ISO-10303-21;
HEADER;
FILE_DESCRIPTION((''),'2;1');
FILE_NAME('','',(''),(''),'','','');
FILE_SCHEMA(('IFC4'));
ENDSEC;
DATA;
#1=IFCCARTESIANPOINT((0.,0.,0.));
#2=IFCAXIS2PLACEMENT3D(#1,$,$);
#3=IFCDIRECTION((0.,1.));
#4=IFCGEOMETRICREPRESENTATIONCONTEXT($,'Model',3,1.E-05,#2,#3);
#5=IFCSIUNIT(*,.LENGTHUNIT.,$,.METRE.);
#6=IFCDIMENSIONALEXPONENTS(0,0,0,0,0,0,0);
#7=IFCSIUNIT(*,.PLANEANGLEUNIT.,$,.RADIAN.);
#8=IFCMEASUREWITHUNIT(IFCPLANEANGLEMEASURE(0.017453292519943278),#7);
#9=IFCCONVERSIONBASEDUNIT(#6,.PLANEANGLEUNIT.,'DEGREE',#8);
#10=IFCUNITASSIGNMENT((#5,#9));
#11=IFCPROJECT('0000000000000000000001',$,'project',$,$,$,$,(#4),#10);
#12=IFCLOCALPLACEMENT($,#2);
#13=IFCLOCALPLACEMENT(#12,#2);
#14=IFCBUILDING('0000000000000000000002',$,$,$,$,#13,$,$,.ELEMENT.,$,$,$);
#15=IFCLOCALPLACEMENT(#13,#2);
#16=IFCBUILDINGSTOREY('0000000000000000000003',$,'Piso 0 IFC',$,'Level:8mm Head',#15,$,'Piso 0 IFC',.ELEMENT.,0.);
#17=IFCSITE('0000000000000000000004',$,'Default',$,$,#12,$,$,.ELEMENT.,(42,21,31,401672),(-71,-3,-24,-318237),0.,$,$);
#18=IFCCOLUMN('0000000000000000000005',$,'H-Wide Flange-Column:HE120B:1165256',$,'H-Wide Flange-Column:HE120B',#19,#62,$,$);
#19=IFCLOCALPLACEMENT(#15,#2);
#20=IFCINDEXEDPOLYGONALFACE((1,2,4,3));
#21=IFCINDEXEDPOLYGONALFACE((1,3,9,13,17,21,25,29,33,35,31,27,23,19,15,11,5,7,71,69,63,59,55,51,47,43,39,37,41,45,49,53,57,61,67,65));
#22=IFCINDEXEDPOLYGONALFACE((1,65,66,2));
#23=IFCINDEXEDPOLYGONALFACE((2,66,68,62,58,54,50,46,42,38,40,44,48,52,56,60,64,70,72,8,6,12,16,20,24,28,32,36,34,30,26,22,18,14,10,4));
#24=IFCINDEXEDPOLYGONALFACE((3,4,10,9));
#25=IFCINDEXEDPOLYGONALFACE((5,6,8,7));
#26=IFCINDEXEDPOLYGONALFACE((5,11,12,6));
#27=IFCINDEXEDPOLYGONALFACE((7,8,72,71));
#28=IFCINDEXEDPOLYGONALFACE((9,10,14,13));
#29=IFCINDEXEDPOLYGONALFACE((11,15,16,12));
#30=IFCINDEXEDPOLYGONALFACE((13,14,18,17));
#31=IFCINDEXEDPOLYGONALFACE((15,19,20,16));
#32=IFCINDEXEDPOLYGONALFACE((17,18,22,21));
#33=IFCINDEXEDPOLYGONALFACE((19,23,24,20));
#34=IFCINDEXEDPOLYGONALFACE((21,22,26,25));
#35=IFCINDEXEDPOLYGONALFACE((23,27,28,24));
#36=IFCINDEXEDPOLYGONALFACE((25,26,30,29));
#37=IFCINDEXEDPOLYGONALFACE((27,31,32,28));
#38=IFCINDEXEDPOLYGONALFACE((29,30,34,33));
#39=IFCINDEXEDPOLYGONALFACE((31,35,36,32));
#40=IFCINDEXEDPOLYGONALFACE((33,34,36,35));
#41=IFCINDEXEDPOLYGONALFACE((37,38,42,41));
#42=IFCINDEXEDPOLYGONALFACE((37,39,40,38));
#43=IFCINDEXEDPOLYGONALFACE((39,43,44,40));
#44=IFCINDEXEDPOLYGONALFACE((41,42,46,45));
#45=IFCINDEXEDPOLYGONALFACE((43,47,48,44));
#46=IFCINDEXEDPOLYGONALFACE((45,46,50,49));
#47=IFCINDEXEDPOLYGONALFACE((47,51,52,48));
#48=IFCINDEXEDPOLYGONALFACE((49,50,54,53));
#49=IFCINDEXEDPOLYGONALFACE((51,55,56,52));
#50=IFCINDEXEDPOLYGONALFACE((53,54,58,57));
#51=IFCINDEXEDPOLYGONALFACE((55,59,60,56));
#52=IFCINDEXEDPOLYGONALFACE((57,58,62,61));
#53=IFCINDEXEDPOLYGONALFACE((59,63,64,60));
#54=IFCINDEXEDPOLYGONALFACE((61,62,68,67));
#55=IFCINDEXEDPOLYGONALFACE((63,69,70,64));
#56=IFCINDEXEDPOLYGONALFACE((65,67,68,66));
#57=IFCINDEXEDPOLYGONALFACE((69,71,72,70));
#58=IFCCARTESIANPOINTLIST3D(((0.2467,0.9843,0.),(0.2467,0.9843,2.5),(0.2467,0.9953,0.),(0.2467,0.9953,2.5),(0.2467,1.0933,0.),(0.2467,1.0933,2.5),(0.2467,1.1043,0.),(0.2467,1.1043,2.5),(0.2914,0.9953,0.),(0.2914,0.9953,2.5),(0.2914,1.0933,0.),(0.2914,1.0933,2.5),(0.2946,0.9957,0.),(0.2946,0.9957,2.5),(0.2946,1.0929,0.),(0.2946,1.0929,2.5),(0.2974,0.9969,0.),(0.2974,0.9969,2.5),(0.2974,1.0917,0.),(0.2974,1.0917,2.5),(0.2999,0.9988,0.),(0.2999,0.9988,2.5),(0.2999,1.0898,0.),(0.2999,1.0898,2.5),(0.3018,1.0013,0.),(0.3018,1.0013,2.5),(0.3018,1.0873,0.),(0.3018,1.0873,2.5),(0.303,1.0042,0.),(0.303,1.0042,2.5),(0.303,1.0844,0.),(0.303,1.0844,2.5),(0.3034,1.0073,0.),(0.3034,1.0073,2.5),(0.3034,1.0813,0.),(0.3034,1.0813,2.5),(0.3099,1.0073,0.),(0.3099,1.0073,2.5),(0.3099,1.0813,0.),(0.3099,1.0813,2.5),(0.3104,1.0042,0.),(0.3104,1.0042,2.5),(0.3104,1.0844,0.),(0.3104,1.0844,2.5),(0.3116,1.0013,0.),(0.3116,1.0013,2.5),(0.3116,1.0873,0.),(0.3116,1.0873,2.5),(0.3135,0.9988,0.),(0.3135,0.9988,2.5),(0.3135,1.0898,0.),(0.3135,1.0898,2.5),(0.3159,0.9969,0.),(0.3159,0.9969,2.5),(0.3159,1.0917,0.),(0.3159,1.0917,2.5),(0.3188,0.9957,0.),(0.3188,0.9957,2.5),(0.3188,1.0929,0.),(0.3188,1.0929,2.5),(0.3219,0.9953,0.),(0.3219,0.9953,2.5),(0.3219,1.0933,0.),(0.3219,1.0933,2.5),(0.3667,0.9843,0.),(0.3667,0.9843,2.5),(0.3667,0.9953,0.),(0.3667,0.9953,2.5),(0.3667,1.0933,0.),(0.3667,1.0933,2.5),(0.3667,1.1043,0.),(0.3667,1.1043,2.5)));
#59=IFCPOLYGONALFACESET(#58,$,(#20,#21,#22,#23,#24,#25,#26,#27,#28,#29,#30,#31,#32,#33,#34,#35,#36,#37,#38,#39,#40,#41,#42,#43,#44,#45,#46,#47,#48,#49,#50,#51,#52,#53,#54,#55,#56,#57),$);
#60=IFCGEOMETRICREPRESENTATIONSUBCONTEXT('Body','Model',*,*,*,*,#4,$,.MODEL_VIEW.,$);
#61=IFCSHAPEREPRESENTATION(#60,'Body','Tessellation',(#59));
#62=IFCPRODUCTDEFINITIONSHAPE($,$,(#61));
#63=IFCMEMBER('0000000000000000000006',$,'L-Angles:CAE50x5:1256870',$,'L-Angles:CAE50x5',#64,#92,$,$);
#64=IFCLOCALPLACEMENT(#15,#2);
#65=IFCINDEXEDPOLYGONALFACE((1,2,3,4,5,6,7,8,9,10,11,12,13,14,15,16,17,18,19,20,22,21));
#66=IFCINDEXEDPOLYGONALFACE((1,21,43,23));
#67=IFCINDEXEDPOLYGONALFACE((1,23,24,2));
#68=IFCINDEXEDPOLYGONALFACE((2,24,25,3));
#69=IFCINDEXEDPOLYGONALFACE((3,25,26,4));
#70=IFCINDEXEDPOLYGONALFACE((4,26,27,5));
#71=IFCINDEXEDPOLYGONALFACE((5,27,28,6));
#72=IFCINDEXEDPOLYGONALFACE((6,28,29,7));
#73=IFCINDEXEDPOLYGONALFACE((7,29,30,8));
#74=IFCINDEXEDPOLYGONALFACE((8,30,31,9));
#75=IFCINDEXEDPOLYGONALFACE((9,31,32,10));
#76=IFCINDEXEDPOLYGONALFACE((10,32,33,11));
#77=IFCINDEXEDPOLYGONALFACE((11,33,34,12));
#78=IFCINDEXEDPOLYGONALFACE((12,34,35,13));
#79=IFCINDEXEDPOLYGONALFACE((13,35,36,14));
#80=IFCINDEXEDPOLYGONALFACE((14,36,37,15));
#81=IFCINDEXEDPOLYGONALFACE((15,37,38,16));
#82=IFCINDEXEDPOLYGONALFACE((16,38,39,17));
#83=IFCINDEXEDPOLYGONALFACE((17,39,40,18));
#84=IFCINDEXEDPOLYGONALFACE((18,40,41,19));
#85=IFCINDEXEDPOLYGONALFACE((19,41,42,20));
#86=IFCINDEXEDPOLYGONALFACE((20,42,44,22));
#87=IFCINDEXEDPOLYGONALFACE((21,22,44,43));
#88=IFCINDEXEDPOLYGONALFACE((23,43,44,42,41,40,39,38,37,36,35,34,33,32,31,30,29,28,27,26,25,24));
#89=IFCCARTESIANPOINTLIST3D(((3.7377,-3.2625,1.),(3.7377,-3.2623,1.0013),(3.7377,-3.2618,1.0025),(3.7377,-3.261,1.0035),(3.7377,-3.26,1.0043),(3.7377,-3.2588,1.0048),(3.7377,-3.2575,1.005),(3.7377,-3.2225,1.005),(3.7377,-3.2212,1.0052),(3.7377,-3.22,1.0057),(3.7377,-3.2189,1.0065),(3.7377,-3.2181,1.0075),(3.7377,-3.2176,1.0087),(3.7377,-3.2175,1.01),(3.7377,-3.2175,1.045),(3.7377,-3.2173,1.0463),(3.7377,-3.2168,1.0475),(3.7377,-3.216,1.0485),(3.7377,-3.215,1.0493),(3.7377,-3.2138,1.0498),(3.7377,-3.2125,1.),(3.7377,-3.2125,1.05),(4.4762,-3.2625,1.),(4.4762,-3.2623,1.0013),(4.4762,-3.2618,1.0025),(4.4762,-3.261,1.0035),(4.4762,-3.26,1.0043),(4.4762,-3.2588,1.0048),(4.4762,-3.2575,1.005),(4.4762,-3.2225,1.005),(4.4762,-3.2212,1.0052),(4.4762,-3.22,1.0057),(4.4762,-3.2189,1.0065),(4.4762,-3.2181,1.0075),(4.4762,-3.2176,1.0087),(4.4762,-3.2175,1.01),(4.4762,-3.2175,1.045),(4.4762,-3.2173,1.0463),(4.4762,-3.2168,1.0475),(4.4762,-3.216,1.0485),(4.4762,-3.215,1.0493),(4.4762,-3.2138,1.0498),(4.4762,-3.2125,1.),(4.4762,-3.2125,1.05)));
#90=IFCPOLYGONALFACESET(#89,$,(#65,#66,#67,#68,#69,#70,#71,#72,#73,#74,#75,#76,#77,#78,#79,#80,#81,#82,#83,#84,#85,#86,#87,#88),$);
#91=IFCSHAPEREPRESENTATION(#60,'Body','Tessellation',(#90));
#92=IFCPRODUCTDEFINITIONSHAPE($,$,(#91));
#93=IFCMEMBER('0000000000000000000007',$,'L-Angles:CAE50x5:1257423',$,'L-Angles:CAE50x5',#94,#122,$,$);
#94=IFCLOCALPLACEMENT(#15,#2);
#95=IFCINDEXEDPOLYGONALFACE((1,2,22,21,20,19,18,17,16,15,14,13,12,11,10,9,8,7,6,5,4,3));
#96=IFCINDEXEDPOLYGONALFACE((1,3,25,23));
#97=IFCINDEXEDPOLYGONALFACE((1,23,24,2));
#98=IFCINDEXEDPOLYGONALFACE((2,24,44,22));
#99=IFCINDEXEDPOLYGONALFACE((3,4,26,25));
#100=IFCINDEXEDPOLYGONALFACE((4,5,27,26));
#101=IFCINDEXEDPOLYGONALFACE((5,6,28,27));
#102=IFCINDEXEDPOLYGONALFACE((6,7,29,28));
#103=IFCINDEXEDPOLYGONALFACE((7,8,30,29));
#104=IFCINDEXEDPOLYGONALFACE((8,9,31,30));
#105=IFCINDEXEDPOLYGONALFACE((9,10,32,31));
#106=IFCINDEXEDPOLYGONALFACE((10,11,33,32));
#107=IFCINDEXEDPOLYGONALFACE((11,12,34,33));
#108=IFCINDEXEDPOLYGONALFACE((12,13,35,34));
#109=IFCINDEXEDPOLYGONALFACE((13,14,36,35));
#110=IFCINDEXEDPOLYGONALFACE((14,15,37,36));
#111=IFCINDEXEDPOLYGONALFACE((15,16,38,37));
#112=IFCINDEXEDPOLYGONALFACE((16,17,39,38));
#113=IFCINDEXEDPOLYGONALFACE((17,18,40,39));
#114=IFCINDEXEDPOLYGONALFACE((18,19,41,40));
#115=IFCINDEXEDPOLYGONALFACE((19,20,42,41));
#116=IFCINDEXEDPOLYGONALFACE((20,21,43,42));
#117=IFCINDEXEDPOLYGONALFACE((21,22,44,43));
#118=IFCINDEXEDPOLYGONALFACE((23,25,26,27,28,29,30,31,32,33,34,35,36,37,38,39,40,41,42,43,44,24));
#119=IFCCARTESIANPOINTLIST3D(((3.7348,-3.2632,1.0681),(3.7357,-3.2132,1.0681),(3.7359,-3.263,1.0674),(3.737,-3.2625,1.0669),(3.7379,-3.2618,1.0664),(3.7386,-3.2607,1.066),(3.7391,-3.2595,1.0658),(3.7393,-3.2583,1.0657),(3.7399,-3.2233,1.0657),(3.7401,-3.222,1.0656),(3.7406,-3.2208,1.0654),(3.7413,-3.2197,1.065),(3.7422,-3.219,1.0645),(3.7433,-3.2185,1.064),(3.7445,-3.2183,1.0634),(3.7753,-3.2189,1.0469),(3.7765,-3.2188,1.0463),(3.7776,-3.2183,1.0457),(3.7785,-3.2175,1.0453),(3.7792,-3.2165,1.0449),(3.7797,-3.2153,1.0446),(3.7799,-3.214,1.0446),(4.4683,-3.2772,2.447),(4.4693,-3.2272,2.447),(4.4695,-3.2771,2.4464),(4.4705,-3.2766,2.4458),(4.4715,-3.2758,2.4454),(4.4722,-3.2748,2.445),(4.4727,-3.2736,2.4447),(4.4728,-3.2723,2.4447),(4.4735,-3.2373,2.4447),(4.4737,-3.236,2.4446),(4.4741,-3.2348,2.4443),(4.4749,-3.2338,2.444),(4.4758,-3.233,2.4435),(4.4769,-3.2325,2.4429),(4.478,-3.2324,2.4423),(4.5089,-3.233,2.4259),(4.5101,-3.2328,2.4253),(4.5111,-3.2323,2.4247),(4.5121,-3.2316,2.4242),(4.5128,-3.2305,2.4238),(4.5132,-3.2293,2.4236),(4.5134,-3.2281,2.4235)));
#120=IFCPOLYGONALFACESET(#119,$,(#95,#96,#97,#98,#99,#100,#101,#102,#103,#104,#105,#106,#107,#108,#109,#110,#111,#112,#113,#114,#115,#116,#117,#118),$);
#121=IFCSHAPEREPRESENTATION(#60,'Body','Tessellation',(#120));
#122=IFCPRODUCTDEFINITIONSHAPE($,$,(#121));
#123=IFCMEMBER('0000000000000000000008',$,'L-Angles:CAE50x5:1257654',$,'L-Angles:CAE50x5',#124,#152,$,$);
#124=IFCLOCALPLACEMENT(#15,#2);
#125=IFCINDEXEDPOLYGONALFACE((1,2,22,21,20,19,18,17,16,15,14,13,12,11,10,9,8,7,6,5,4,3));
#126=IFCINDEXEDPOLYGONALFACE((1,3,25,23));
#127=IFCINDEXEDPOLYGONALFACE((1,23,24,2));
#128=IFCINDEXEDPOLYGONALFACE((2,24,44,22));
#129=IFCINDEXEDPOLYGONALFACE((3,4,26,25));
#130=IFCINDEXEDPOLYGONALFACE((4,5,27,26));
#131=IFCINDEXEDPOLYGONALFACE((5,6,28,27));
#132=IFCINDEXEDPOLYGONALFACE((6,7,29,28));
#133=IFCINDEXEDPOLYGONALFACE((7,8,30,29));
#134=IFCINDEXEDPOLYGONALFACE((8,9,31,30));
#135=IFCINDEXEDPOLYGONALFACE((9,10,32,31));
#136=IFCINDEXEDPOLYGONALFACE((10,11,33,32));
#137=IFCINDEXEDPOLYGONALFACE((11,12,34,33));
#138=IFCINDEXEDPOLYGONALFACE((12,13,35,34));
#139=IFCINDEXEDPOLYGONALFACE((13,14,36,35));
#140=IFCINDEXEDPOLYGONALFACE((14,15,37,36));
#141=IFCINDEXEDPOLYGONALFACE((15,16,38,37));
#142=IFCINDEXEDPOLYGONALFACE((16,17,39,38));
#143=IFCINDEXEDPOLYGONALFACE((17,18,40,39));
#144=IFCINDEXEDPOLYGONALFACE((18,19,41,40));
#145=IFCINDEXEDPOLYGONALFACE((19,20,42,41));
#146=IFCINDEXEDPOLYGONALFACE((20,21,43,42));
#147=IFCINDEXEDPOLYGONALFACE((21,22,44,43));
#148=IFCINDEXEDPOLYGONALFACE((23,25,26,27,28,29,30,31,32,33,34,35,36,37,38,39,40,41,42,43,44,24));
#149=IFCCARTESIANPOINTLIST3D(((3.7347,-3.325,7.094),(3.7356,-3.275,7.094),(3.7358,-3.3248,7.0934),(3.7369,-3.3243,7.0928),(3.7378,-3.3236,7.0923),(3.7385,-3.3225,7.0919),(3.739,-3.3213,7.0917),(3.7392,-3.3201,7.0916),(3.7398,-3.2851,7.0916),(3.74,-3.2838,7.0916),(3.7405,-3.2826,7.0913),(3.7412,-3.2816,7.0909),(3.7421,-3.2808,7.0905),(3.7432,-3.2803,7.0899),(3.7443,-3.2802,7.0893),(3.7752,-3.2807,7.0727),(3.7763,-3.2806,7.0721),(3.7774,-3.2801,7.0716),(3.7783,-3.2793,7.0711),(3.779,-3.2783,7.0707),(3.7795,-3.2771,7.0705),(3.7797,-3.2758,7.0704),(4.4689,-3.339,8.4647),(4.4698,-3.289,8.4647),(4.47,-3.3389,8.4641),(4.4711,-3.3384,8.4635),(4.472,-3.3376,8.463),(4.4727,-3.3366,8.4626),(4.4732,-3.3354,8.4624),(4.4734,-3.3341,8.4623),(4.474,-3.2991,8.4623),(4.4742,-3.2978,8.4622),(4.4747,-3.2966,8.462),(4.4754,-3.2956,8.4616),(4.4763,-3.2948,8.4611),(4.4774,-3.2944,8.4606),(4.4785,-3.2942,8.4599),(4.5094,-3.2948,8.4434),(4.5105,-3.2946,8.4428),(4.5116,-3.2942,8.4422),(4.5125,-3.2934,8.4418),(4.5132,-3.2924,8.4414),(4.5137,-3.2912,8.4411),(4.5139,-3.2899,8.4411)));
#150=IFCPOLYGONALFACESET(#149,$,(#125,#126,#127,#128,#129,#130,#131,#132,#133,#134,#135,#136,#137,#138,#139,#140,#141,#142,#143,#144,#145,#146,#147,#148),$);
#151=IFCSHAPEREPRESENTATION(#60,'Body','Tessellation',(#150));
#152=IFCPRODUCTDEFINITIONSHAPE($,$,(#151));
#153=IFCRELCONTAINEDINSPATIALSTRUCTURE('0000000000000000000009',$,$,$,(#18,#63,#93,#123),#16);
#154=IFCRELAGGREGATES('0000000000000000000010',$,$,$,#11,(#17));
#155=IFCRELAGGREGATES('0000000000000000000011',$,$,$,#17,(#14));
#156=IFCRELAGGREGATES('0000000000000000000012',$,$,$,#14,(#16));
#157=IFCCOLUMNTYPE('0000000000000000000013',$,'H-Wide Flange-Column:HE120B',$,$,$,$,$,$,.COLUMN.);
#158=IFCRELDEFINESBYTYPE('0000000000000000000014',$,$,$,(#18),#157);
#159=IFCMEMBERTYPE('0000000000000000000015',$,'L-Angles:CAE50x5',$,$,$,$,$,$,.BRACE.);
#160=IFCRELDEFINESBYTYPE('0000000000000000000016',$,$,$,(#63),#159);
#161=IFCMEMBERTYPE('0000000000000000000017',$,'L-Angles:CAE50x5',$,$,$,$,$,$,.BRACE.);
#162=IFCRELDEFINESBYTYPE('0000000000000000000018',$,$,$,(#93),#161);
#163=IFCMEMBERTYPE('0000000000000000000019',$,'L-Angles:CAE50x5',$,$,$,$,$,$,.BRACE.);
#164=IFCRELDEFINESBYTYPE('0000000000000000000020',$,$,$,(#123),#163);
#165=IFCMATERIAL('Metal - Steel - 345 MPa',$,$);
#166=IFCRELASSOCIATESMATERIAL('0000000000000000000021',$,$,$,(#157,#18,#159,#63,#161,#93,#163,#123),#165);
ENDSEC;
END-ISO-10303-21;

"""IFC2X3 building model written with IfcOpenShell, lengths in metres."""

from ifc_helpers import new_model, entity, si_unit, converted_unit, direction, frame, frame_2d, origin, place, context, subcontext, project, spatial, polyline, circle_curve, parameter, trimmed, segment, composite_curve, i_section, outline, extrude, source, transform, mapped, material, type_object, type_shapes, element, save


model = new_model("IFC2X3")

# Units and contexts
model_context = context("Model", 3, precision=1e-05, world=origin(), true_north=direction((0.0, 1.0)))
body_context = subcontext(model_context, "Body", "Model", "MODEL_VIEW")
ifc_project = project(units=[si_unit("LENGTHUNIT", "METRE"), converted_unit("PLANEANGLEUNIT", "DEGREE", entity("IfcPlaneAngleMeasure", 0.017453292519943278), si_unit("PLANEANGLEUNIT", "RADIAN"), dimensions=[0, 0, 0, 0, 0, 0, 0])], contexts=[model_context])

# Site, building, storey
site_placement = place(None, origin())
site = spatial("IfcSite", under=ifc_project, at=site_placement, Name="Default", CompositionType="ELEMENT", RefLatitude=(42, 21, 31, 401672), RefLongitude=(-71, -3, -24, -318237), RefElevation=0.0)
building_placement = place(site_placement, origin())
building = spatial("IfcBuilding", under=site, at=building_placement, CompositionType="ELEMENT")
storey_placement = place(building_placement, origin())
storey = spatial("IfcBuildingStorey", under=building, at=storey_placement, Name="Piso 0 IFC", ObjectType="Level:8mm Head", LongName="Piso 0 IFC", CompositionType="ELEMENT", Elevation=0.0)

# Column
ifc_material_1 = material(Name="Metal - Steel - 345 MPa")
column_type_1 = type_object("IfcColumnType", Name="H-Wide Flange-Column:HE120B", PredefinedType="COLUMN", material=ifc_material_1)
shared_shape_1 = source(origin(), body_context, "Body", "SweptSolid", [
    extrude(i_section(OverallWidth=0.12, OverallDepth=0.12, WebThickness=0.0065, FlangeThickness=0.011, FilletRadius=0.012, at=frame_2d((0.0, 0.0), x_axis=(1.0, 0.0))), frame((0.0, 0.0, 0.0), z_axis=(0.0, 0.0, 1.0), x_axis=(-1.0, 0.0, 0.0)), (0.0, 0.0, 1.0), 2.5),
])
type_shapes(column_type_1, [shared_shape_1])
column_placement = place(storey_placement, frame((0.3067, 1.0443, 0.0)))
element("IfcColumn", 1, at=column_placement, inside=storey, type_object=column_type_1, material=ifc_material_1, Name="H-Wide Flange-Column:HE120B:1165256", ObjectType="H-Wide Flange-Column:HE120B", context=body_context, shape_type="MappedRepresentation", body=[
    mapped(shared_shape_1, transform((0.0, 0.0, 0.0), scale=1.0)),
])

# Members
member_type_1 = type_object("IfcMemberType", Name="L-Angles:CAE50x5", PredefinedType="BRACE", material=ifc_material_1)
shared_shape_2 = source(origin(), body_context, "Body", "SweptSolid", [
    extrude(outline(composite_curve([segment(polyline([(-0.0164, -0.0164), (0.0336, -0.0164)]), True, "CONTINUOUS"), segment(trimmed(circle_curve(frame_2d((0.0286, -0.0164), x_axis=(1.0, 0.0)), 0.005), [parameter(0.0)], [parameter(90.0)], True, "PARAMETER"), True, "CONTINUOUS"), segment(polyline([(0.0286, -0.0114), (-0.0064, -0.0114)]), True, "CONTINUOUS"), segment(trimmed(circle_curve(frame_2d((-0.0064, -0.0064), x_axis=(1.0, 0.0)), 0.005), [parameter(180.0)], [parameter(270.0)], True, "PARAMETER"), False, "CONTINUOUS"), segment(polyline([(-0.0114, -0.0064), (-0.0114, 0.0286)]), True, "CONTINUOUS"), segment(trimmed(circle_curve(frame_2d((-0.0164, 0.0286), x_axis=(1.0, 0.0)), 0.005), [parameter(0.0)], [parameter(90.0)], True, "PARAMETER"), True, "CONTINUOUS"), segment(polyline([(-0.0164, 0.0336), (-0.0164, -0.0164)]), True, "CONTINUOUS")], self_intersect=False)), frame((-0.369, -0.0024, -0.0024), z_axis=(1.0, 0.0, 0.0), x_axis=(0.0, -1.0, 0.0)), (0.0, 0.0, 1.0), 0.7385),
])
type_shapes(member_type_1, [shared_shape_2])
member_1_placement = place(storey_placement, frame((4.1067, -3.2265, 1.014), z_axis=(0.0, 1.0, 0.0), x_axis=(1.0, 0.0, 0.0)))
element("IfcMember", 2, at=member_1_placement, inside=storey, type_object=member_type_1, material=ifc_material_1, Name="L-Angles:CAE50x5:1256870", ObjectType="L-Angles:CAE50x5", context=body_context, shape_type="MappedRepresentation", body=[
    mapped(shared_shape_2, transform((0.0, 0.0, 0.0), scale=1.0)),
])
member_type_2 = type_object("IfcMemberType", Name="L-Angles:CAE50x5", PredefinedType="BRACE", material=ifc_material_1)
shared_shape_3 = source(origin(), body_context, "Body", "SweptSolid", [
    extrude(outline(composite_curve([segment(polyline([(-0.0164, -0.0164), (0.0336, -0.0164)]), True, "CONTINUOUS"), segment(trimmed(circle_curve(frame_2d((0.0286, -0.0164), x_axis=(1.0, 0.0)), 0.005), [parameter(0.0)], [parameter(90.0)], True, "PARAMETER"), True, "CONTINUOUS"), segment(polyline([(0.0286, -0.0114), (-0.0064, -0.0114)]), True, "CONTINUOUS"), segment(trimmed(circle_curve(frame_2d((-0.0064, -0.0064), x_axis=(1.0, 0.0)), 0.005), [parameter(180.0)], [parameter(270.0)], True, "PARAMETER"), False, "CONTINUOUS"), segment(polyline([(-0.0114, -0.0064), (-0.0114, 0.0286)]), True, "CONTINUOUS"), segment(trimmed(circle_curve(frame_2d((-0.0164, 0.0286), x_axis=(1.0, 0.0)), 0.005), [parameter(0.0)], [parameter(90.0)], True, "PARAMETER"), True, "CONTINUOUS"), segment(polyline([(-0.0164, 0.0336), (-0.0164, -0.0164)]), True, "CONTINUOUS")], self_intersect=False)), frame((-0.7905, -0.0024, -0.0024), z_axis=(1.0, 0.0, 0.0), x_axis=(0.0, -1.0, 0.0)), (0.0, 0.0, 1.0), 1.562),
])
type_shapes(member_type_2, [shared_shape_3])
member_2_placement = place(storey_placement, frame((4.1191, -3.2345, 1.7593), z_axis=(-0.882655, 0.01689, 0.469718), x_axis=(0.469632, -0.008987, 0.882816)))
element("IfcMember", 3, at=member_2_placement, inside=storey, type_object=member_type_2, material=ifc_material_1, Name="L-Angles:CAE50x5:1257423", ObjectType="L-Angles:CAE50x5", context=body_context, shape_type="MappedRepresentation", body=[
    mapped(shared_shape_3, transform((0.0, 0.0, 0.0), scale=1.0)),
])
member_type_3 = type_object("IfcMemberType", Name="L-Angles:CAE50x5", PredefinedType="BRACE", material=ifc_material_1)
shared_shape_4 = source(origin(), body_context, "Body", "SweptSolid", [
    extrude(outline(composite_curve([segment(polyline([(-0.0164, -0.0164), (0.0336, -0.0164)]), True, "CONTINUOUS"), segment(trimmed(circle_curve(frame_2d((0.0286, -0.0164), x_axis=(1.0, 0.0)), 0.005), [parameter(0.0)], [parameter(90.0)], True, "PARAMETER"), True, "CONTINUOUS"), segment(polyline([(0.0286, -0.0114), (-0.0064, -0.0114)]), True, "CONTINUOUS"), segment(trimmed(circle_curve(frame_2d((-0.0064, -0.0064), x_axis=(1.0, 0.0)), 0.005), [parameter(180.0)], [parameter(270.0)], True, "PARAMETER"), False, "CONTINUOUS"), segment(polyline([(-0.0114, -0.0064), (-0.0114, 0.0286)]), True, "CONTINUOUS"), segment(trimmed(circle_curve(frame_2d((-0.0164, 0.0286), x_axis=(1.0, 0.0)), 0.005), [parameter(0.0)], [parameter(90.0)], True, "PARAMETER"), True, "CONTINUOUS"), segment(polyline([(-0.0164, 0.0336), (-0.0164, -0.0164)]), True, "CONTINUOUS")], self_intersect=False)), frame((-0.7865, -0.0024, -0.0024), z_axis=(1.0, 0.0, 0.0), x_axis=(0.0, -1.0, 0.0)), (0.0, 0.0, 1.0), 1.555),
])
type_shapes(member_type_3, [shared_shape_4])
member_3_placement = place(storey_placement, frame((4.119, -3.2963, 7.7807), z_axis=(-0.881304, 0.016869, 0.472248), x_axis=(0.472162, -0.009038, 0.881465)))
element("IfcMember", 4, at=member_3_placement, inside=storey, type_object=member_type_3, material=ifc_material_1, Name="L-Angles:CAE50x5:1257654", ObjectType="L-Angles:CAE50x5", context=body_context, shape_type="MappedRepresentation", body=[
    mapped(shared_shape_4, transform((0.0, 0.0, 0.0), scale=1.0)),
])

save(model, "model.ifc")
